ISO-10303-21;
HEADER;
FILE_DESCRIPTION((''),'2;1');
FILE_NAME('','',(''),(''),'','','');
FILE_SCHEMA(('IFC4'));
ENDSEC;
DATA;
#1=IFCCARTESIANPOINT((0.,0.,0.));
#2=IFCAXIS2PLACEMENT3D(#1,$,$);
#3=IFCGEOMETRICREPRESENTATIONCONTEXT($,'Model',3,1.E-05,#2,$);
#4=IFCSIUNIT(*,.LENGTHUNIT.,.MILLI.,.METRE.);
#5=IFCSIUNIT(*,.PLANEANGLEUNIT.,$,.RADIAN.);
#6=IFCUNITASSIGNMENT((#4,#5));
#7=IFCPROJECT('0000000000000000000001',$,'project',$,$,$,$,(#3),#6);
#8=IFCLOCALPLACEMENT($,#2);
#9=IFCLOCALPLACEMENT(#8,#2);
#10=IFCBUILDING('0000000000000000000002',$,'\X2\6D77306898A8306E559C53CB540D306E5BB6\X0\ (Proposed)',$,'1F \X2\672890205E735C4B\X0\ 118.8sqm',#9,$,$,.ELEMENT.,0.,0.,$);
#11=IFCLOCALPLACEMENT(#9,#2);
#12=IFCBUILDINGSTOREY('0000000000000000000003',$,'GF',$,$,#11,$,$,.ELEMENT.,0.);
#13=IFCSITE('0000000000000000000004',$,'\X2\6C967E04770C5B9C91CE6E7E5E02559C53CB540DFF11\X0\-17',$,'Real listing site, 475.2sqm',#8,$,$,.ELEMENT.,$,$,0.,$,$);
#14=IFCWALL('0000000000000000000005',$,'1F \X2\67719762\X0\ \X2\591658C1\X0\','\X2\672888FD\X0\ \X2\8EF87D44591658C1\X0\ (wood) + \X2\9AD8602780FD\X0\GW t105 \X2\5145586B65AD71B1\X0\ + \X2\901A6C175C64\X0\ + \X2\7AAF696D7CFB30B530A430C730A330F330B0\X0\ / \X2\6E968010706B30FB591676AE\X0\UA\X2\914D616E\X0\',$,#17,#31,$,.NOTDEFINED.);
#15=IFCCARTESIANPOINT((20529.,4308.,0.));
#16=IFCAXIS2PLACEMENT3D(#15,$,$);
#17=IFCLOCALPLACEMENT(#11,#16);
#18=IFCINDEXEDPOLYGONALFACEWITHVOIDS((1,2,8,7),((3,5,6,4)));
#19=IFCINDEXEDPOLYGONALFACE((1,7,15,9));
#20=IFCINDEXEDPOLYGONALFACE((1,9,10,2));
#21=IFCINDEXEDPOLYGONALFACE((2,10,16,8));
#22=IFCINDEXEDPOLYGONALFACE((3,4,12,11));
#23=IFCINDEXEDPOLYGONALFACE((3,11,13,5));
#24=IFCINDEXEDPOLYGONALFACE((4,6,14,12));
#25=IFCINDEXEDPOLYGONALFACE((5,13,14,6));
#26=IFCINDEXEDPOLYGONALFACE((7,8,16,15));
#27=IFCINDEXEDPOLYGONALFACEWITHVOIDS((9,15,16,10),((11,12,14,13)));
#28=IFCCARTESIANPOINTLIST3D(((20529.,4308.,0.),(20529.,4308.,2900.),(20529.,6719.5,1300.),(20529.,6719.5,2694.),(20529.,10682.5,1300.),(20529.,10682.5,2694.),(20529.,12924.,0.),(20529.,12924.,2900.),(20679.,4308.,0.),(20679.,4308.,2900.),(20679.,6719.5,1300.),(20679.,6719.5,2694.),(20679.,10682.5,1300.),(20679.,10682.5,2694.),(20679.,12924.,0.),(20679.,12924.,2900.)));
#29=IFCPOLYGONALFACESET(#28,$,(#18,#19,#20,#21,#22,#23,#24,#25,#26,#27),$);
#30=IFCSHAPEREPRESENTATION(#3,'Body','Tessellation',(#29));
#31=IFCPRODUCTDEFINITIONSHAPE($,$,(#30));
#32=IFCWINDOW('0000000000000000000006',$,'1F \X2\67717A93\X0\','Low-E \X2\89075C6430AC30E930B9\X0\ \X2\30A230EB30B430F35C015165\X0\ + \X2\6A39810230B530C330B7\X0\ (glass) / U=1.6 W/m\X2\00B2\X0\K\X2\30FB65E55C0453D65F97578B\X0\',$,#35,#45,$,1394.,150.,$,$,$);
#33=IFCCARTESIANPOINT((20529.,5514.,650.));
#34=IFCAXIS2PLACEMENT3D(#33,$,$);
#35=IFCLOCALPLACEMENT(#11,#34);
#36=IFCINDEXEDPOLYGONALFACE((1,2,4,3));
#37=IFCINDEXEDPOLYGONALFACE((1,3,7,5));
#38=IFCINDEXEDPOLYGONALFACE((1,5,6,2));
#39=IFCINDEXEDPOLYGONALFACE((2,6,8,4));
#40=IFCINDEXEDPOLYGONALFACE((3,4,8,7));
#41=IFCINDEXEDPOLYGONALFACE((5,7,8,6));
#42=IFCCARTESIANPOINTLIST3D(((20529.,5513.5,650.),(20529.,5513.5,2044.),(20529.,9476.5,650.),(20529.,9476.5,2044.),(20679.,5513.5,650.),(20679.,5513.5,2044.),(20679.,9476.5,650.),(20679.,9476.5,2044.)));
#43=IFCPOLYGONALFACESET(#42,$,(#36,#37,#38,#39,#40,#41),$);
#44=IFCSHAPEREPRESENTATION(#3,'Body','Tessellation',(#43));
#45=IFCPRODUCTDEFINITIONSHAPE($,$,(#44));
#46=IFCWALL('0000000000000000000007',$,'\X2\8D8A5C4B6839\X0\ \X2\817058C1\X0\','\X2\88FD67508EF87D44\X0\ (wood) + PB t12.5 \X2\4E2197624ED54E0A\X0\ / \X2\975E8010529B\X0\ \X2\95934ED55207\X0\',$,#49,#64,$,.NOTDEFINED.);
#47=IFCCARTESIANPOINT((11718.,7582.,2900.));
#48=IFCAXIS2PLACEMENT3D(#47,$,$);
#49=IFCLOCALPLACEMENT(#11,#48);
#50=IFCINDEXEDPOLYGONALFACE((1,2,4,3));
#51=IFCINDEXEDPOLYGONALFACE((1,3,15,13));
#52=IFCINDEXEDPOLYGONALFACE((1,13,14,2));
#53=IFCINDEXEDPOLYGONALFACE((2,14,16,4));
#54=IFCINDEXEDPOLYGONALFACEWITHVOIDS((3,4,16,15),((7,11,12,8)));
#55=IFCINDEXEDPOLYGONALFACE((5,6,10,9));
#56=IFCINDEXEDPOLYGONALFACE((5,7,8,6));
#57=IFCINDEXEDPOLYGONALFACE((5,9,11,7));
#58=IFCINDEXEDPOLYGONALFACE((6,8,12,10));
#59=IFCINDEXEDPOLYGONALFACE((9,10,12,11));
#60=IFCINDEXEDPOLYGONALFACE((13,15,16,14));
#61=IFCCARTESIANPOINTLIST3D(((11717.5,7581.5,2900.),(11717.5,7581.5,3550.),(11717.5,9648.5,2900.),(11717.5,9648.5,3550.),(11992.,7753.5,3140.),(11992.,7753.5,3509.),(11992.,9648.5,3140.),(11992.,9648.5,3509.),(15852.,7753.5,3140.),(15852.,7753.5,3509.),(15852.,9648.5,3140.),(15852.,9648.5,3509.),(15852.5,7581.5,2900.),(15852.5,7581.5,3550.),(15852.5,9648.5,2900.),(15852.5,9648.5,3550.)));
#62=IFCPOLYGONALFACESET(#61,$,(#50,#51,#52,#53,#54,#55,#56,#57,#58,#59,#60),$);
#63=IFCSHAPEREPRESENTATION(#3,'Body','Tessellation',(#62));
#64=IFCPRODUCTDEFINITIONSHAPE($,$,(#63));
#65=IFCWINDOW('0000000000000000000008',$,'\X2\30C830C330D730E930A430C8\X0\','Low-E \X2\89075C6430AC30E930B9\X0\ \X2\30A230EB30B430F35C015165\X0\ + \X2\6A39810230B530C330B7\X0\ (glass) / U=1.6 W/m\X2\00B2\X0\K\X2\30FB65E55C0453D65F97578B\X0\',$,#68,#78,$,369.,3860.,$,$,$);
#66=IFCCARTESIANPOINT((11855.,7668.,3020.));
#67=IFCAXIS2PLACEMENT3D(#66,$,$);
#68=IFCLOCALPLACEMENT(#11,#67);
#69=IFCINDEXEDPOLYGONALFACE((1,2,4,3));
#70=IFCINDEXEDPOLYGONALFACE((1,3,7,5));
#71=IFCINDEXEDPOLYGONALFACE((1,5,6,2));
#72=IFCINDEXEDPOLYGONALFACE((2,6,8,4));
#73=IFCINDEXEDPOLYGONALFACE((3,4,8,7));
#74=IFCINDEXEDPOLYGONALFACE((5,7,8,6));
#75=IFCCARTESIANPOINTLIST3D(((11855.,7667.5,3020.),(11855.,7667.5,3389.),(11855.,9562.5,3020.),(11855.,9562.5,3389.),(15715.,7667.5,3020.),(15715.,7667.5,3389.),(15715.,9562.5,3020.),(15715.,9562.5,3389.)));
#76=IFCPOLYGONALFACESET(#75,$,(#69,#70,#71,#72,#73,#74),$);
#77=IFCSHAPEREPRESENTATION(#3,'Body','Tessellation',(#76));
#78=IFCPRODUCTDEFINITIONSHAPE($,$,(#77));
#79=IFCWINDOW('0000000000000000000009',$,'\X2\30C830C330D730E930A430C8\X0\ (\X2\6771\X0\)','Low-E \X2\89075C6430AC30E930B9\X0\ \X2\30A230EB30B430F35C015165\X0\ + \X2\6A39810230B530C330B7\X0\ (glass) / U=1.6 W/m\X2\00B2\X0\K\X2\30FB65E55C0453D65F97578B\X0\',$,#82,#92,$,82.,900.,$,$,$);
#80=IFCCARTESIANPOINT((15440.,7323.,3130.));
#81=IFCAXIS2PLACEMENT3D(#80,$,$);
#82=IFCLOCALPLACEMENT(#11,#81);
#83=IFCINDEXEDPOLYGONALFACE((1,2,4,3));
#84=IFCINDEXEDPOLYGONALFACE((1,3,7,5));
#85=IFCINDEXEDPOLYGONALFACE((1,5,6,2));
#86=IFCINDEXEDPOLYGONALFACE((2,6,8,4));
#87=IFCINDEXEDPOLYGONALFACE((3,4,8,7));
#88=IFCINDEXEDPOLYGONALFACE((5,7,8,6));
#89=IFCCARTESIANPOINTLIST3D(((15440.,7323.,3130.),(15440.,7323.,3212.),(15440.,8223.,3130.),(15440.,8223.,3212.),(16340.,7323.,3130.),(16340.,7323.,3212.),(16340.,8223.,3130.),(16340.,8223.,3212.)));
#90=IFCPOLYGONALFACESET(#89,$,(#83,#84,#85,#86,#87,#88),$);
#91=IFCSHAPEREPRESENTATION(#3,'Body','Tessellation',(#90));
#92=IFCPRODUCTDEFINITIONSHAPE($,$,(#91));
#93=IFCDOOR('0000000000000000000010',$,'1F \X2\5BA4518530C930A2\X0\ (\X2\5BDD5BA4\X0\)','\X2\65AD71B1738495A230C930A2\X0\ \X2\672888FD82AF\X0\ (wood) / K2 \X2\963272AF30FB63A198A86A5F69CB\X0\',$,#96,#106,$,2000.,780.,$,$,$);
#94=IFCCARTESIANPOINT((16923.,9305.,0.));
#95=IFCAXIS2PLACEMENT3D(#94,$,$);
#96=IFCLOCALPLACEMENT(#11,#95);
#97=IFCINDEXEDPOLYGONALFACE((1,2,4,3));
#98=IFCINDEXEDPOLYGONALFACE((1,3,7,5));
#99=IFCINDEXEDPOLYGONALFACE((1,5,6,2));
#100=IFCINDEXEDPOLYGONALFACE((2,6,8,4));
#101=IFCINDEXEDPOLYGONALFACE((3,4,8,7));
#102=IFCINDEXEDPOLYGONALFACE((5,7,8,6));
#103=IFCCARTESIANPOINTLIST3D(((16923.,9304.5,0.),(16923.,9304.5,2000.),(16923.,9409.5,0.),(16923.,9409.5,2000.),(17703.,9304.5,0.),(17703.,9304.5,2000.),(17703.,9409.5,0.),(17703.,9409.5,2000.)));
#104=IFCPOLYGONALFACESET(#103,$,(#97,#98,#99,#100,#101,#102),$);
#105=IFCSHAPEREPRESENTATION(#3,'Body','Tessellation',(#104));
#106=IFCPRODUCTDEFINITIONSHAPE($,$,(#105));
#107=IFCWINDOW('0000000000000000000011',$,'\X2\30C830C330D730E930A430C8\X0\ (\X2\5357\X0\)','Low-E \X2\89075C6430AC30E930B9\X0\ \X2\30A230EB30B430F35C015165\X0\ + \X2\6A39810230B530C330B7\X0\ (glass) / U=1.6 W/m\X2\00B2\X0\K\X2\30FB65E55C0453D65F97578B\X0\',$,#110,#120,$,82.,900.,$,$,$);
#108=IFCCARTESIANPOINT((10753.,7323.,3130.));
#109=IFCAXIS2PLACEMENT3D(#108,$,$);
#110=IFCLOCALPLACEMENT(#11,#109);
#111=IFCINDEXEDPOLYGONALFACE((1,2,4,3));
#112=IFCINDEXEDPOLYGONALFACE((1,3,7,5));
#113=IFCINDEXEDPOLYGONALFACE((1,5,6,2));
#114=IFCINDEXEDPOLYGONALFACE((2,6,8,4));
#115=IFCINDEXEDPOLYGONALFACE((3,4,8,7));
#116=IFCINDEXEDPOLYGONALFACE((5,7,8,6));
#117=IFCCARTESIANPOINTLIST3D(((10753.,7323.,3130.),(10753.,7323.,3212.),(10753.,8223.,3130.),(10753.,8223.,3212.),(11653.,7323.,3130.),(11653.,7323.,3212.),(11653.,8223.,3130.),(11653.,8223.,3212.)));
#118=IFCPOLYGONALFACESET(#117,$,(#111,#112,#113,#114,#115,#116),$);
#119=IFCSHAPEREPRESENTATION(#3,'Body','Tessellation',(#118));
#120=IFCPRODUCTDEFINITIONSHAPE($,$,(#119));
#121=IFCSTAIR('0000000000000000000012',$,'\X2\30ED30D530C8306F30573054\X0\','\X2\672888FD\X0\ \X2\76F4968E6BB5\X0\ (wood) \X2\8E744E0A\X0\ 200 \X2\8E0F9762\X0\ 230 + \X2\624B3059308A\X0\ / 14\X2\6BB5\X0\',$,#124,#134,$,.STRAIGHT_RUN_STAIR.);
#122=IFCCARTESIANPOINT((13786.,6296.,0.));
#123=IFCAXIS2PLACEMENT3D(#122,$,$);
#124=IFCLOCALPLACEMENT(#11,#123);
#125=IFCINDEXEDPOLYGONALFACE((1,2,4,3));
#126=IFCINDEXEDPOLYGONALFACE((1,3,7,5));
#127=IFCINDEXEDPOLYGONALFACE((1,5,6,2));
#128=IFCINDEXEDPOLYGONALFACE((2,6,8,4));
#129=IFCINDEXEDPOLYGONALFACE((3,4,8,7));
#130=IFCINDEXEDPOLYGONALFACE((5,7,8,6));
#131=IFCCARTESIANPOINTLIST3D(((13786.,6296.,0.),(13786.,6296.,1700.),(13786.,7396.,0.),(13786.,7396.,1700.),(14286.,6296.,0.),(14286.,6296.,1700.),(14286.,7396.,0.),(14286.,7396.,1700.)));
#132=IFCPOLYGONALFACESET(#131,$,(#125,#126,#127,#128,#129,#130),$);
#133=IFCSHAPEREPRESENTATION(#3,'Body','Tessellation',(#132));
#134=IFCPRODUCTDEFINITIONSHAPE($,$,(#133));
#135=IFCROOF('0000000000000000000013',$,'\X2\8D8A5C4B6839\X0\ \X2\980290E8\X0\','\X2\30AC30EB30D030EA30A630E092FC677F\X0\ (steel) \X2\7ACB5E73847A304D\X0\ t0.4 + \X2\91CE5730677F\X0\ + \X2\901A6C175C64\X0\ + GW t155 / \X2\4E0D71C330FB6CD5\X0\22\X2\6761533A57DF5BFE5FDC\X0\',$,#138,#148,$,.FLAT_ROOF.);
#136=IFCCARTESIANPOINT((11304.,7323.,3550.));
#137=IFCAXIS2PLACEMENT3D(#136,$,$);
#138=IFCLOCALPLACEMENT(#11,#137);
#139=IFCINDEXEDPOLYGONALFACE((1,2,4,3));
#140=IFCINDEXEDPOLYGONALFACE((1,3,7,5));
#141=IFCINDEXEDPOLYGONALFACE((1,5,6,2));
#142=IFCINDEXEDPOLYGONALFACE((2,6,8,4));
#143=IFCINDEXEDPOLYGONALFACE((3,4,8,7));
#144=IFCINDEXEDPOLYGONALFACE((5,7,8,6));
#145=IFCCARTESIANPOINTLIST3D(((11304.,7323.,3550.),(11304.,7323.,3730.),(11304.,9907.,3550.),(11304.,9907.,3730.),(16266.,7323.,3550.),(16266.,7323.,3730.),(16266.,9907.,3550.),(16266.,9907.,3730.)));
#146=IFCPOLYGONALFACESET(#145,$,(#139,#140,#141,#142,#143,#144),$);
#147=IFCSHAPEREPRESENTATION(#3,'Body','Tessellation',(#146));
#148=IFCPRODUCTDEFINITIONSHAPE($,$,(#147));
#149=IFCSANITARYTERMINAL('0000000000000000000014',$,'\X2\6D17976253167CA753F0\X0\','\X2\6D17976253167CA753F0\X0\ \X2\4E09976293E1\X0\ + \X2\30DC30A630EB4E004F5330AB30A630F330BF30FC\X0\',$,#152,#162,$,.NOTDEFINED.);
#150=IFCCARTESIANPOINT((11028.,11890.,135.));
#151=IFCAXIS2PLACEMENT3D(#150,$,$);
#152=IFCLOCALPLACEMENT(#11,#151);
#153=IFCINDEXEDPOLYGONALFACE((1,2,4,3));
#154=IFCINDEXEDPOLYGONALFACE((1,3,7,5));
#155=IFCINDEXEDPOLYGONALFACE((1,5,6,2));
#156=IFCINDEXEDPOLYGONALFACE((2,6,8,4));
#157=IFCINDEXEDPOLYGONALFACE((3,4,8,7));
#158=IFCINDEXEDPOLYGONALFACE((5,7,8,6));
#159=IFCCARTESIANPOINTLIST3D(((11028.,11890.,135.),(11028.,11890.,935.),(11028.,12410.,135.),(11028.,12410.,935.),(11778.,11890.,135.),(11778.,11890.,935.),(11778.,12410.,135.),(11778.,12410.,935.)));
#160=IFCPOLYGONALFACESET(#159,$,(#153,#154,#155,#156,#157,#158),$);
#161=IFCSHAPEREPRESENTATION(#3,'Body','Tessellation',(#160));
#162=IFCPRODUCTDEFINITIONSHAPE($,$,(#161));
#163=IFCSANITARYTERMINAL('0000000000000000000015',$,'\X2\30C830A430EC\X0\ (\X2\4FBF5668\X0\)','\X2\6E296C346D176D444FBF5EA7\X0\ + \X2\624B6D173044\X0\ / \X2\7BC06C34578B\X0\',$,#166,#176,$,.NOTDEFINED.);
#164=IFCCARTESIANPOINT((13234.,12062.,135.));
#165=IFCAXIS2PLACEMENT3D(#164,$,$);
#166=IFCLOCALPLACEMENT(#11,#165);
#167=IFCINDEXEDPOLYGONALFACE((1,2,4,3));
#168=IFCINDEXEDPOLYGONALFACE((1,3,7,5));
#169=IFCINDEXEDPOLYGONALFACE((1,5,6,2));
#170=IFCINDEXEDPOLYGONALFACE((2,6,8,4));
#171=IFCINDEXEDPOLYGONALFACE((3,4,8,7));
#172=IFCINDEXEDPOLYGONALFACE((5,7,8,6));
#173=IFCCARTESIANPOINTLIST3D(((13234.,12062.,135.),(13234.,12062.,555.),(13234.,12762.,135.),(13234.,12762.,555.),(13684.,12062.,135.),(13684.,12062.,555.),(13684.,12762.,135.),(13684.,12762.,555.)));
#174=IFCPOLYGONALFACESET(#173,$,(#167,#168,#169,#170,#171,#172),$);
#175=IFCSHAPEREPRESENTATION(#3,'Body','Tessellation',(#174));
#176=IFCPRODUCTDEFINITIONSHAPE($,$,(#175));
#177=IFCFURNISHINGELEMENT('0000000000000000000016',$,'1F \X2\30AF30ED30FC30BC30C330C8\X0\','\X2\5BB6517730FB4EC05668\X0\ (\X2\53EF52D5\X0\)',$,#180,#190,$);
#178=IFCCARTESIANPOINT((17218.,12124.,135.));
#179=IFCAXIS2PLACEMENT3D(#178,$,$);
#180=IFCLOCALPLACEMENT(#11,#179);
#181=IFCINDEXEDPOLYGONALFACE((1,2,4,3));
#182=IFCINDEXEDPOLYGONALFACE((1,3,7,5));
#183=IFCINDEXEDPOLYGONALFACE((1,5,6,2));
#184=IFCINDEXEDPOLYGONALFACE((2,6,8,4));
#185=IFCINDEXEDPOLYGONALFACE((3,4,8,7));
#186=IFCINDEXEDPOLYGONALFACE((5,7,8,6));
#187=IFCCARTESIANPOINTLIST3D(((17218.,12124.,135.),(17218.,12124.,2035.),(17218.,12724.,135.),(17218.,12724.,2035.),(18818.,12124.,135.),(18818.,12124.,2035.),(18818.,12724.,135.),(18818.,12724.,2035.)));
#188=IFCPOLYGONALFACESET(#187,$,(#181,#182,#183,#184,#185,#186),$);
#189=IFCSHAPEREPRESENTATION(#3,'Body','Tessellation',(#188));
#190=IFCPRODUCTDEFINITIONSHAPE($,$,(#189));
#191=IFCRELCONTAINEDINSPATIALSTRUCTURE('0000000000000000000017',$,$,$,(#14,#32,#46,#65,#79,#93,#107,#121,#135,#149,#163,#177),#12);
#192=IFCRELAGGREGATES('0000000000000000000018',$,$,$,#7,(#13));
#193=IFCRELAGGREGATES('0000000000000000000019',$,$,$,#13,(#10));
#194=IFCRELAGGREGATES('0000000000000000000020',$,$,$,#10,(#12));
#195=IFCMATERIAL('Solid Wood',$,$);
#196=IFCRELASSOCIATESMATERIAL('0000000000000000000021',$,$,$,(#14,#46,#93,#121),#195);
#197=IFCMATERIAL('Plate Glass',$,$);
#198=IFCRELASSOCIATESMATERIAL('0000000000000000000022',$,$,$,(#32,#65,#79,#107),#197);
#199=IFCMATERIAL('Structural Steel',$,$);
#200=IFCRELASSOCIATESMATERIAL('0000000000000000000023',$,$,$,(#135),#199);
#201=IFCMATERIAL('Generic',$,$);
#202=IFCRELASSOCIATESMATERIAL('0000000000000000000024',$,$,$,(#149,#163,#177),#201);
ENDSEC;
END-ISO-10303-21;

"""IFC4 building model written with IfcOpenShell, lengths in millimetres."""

from ifc_helpers import new_model, si_unit, frame, frame_2d, origin, place, context, project, spatial, rectangle, extrude, material, element, fill, save


model = new_model("IFC4")

# Units and contexts
model_context = context("Model", 3, precision=1e-05, world=origin())
ifc_project = project(units=[si_unit("LENGTHUNIT", "METRE", prefix="MILLI"), si_unit("PLANEANGLEUNIT", "RADIAN")], contexts=[model_context])

# Site, building, storey
site_placement = place(None, origin())
site = spatial("IfcSite", under=ifc_project, at=site_placement, Name="沖縄県宜野湾市喜友名１-17", ObjectType="Real listing site, 475.2sqm", CompositionType="ELEMENT", RefElevation=0.0)
building_placement = place(site_placement, origin())
building = spatial("IfcBuilding", under=site, at=building_placement, Name="海と風の喜友名の家 (Proposed)", ObjectType="1F 木造平屋 118.8sqm", CompositionType="ELEMENT", ElevationOfRefHeight=0.0, ElevationOfTerrain=0.0)
storey_placement = place(building_placement, origin())
storey = spatial("IfcBuildingStorey", under=building, at=storey_placement, Name="GF", CompositionType="ELEMENT", Elevation=0.0)

# Wall, opening, window
ifc_material_1 = material(Name="Solid Wood")
wall_1_placement = place(storey_placement, frame((20529.0, 4308.0, 0.0)))
wall_1 = element("IfcWall", 1, at=wall_1_placement, inside=storey, material=ifc_material_1, Name="1F 東面 外壁", Description="木製 軸組外壁 (wood) + 高性能GW t105 充填断熱 + 通気層 + 窯業系サイディング / 準耐火・外皮UA配慮", PredefinedType="NOTDEFINED", context=model_context, shape_type="SweptSolid", body=[
    extrude(rectangle(XDim=150.0, YDim=8616.0, at=frame_2d((75.0, 4308.0))), frame((20529.0, 4308.0, 0.0)), (0.0, 0.0, 1.0), 2900.0),
])
opening_1_placement = place(storey_placement, frame((20529.0, 5514.0, 650.0)))
opening_1 = element("IfcOpeningElement", 2, at=opening_1_placement, cuts=wall_1, PredefinedType="NOTDEFINED", context=model_context, shape_type="SweptSolid", body=[
    extrude(rectangle(XDim=150.0, YDim=3963.0, at=frame_2d((75.0, 1981.0))), frame((20529.0, 5514.0, 650.0)), (0.0, 0.0, 1.0), 1394.0),
])
ifc_material_2 = material(Name="Plate Glass")
window_1_placement = place(storey_placement, frame((20529.0, 5514.0, 650.0)))
window_1 = element("IfcWindow", 3, at=window_1_placement, inside=storey, material=ifc_material_2, Name="1F 東窓", Description="Low-E 複層ガラス アルゴン封入 + 樹脂サッシ (glass) / U=1.6 W/m²K・日射取得型", OverallHeight=1394.0, OverallWidth=150.0, context=model_context, shape_type="SweptSolid", body=[
    extrude(rectangle(XDim=150.0, YDim=3963.0, at=frame_2d((75.0, 1981.0))), frame((20529.0, 5514.0, 650.0)), (0.0, 0.0, 1.0), 1394.0),
])
fill(opening_1, window_1)

# Wall, openings, windows
wall_2_placement = place(storey_placement, frame((11718.0, 7582.0, 2900.0)))
wall_2 = element("IfcWall", 4, at=wall_2_placement, inside=storey, material=ifc_material_1, Name="越屋根 腰壁", Description="製材軸組 (wood) + PB t12.5 両面仕上 / 非耐力 間仕切", PredefinedType="NOTDEFINED", context=model_context, shape_type="SweptSolid", body=[
    extrude(rectangle(XDim=4135.0, YDim=2067.0, at=frame_2d((2067.0, 1033.0))), frame((11718.0, 7582.0, 2900.0)), (0.0, 0.0, 1.0), 650.0),
])
opening_2_placement = place(storey_placement, frame((11855.0, 7668.0, 3020.0)))
opening_2 = element("IfcOpeningElement", 5, at=opening_2_placement, cuts=wall_2, PredefinedType="NOTDEFINED", context=model_context, shape_type="SweptSolid", body=[
    extrude(rectangle(XDim=3860.0, YDim=1895.0, at=frame_2d((1930.0, 947.0))), frame((11855.0, 7668.0, 3020.0)), (0.0, 0.0, 1.0), 369.0),
])
opening_3_placement = place(storey_placement, frame((15440.0, 7323.0, 3130.0)))
opening_3 = element("IfcOpeningElement", 6, at=opening_3_placement, cuts=wall_2, PredefinedType="NOTDEFINED", context=model_context, shape_type="SweptSolid", body=[
    extrude(rectangle(XDim=900.0, YDim=900.0, at=frame_2d((450.0, 450.0))), frame((15440.0, 7323.0, 3130.0)), (0.0, 0.0, 1.0), 82.0),
])
window_2_placement = place(storey_placement, frame((11855.0, 7668.0, 3020.0)))
window_2 = element("IfcWindow", 7, at=window_2_placement, inside=storey, material=ifc_material_2, Name="トップライト", Description="Low-E 複層ガラス アルゴン封入 + 樹脂サッシ (glass) / U=1.6 W/m²K・日射取得型", OverallHeight=369.0, OverallWidth=3860.0, context=model_context, shape_type="SweptSolid", body=[
    extrude(rectangle(XDim=3860.0, YDim=1895.0, at=frame_2d((1930.0, 947.0))), frame((11855.0, 7668.0, 3020.0)), (0.0, 0.0, 1.0), 369.0),
])
fill(opening_2, window_2)
window_3_placement = place(storey_placement, frame((15440.0, 7323.0, 3130.0)))
window_3 = element("IfcWindow", 8, at=window_3_placement, inside=storey, material=ifc_material_2, Name="トップライト (東)", Description="Low-E 複層ガラス アルゴン封入 + 樹脂サッシ (glass) / U=1.6 W/m²K・日射取得型", OverallHeight=82.0, OverallWidth=900.0, context=model_context, shape_type="SweptSolid", body=[
    extrude(rectangle(XDim=900.0, YDim=900.0, at=frame_2d((450.0, 450.0))), frame((15440.0, 7323.0, 3130.0)), (0.0, 0.0, 1.0), 82.0),
])
fill(opening_3, window_3)

# Door
door_placement = place(storey_placement, frame((16923.0, 9305.0, 0.0)))
element("IfcDoor", 9, at=door_placement, inside=storey, material=ifc_material_1, Name="1F 室内ドア (寝室)", Description="断熱玄関ドア 木製芯 (wood) / K2 防犯・採風機構", OverallHeight=2000.0, OverallWidth=780.0, context=model_context, shape_type="SweptSolid", body=[
    extrude(rectangle(XDim=780.0, YDim=105.0, at=frame_2d((390.0, 52.0))), frame((16923.0, 9305.0, 0.0)), (0.0, 0.0, 1.0), 2000.0),
])

# Window
window_4_placement = place(storey_placement, frame((10753.0, 7323.0, 3130.0)))
element("IfcWindow", 10, at=window_4_placement, inside=storey, material=ifc_material_2, Name="トップライト (南)", Description="Low-E 複層ガラス アルゴン封入 + 樹脂サッシ (glass) / U=1.6 W/m²K・日射取得型", OverallHeight=82.0, OverallWidth=900.0, context=model_context, shape_type="SweptSolid", body=[
    extrude(rectangle(XDim=900.0, YDim=900.0, at=frame_2d((450.0, 450.0))), frame((10753.0, 7323.0, 3130.0)), (0.0, 0.0, 1.0), 82.0),
])

# Stair
stair_placement = place(storey_placement, frame((13786.0, 6296.0, 0.0)))
element("IfcStair", 11, at=stair_placement, inside=storey, material=ifc_material_1, Name="ロフトはしご", Description="木製 直階段 (wood) 蹴上 200 踏面 230 + 手すり / 14段", PredefinedType="STRAIGHT_RUN_STAIR", context=model_context, shape_type="SweptSolid", body=[
    extrude(rectangle(XDim=500.0, YDim=1100.0, at=frame_2d((250.0, 550.0))), frame((13786.0, 6296.0, 0.0)), (0.0, 0.0, 1.0), 1700.0),
])

# Roof
ifc_material_3 = material(Name="Structural Steel")
roof_placement = place(storey_placement, frame((11304.0, 7323.0, 3550.0)))
element("IfcRoof", 12, at=roof_placement, inside=storey, material=ifc_material_3, Name="越屋根 頂部", Description="ガルバリウム鋼板 (steel) 立平葺き t0.4 + 野地板 + 通気層 + GW t155 / 不燃・法22条区域対応", PredefinedType="FLAT_ROOF", context=model_context, shape_type="SweptSolid", body=[
    extrude(rectangle(XDim=4962.0, YDim=2584.0, at=frame_2d((2481.0, 1292.0))), frame((11304.0, 7323.0, 3550.0)), (0.0, 0.0, 1.0), 180.0),
])

# Sanitary terminals
ifc_material_4 = material(Name="Generic")
sanitary_terminal_1_placement = place(storey_placement, frame((11028.0, 11890.0, 135.0)))
element("IfcSanitaryTerminal", 13, at=sanitary_terminal_1_placement, inside=storey, material=ifc_material_4, Name="洗面化粧台", Description="洗面化粧台 三面鏡 + ボウル一体カウンター", PredefinedType="NOTDEFINED", context=model_context, shape_type="SweptSolid", body=[
    extrude(rectangle(XDim=750.0, YDim=520.0, at=frame_2d((375.0, 260.0))), frame((11028.0, 11890.0, 135.0)), (0.0, 0.0, 1.0), 800.0),
])
sanitary_terminal_2_placement = place(storey_placement, frame((13234.0, 12062.0, 135.0)))
element("IfcSanitaryTerminal", 14, at=sanitary_terminal_2_placement, inside=storey, material=ifc_material_4, Name="トイレ (便器)", Description="温水洗浄便座 + 手洗い / 節水型", PredefinedType="NOTDEFINED", context=model_context, shape_type="SweptSolid", body=[
    extrude(rectangle(XDim=450.0, YDim=700.0, at=frame_2d((225.0, 350.0))), frame((13234.0, 12062.0, 135.0)), (0.0, 0.0, 1.0), 420.0),
])

# Furnishing element
furnishing_1_placement = place(storey_placement, frame((17218.0, 12124.0, 135.0)))
element("IfcFurnishingElement", 15, at=furnishing_1_placement, inside=storey, material=ifc_material_4, Name="1F クローゼット", Description="家具・什器 (可動)", context=model_context, shape_type="SweptSolid", body=[
    extrude(rectangle(XDim=1600.0, YDim=600.0, at=frame_2d((800.0, 300.0))), frame((17218.0, 12124.0, 135.0)), (0.0, 0.0, 1.0), 1900.0),
])

save(model, "model.ifc")
